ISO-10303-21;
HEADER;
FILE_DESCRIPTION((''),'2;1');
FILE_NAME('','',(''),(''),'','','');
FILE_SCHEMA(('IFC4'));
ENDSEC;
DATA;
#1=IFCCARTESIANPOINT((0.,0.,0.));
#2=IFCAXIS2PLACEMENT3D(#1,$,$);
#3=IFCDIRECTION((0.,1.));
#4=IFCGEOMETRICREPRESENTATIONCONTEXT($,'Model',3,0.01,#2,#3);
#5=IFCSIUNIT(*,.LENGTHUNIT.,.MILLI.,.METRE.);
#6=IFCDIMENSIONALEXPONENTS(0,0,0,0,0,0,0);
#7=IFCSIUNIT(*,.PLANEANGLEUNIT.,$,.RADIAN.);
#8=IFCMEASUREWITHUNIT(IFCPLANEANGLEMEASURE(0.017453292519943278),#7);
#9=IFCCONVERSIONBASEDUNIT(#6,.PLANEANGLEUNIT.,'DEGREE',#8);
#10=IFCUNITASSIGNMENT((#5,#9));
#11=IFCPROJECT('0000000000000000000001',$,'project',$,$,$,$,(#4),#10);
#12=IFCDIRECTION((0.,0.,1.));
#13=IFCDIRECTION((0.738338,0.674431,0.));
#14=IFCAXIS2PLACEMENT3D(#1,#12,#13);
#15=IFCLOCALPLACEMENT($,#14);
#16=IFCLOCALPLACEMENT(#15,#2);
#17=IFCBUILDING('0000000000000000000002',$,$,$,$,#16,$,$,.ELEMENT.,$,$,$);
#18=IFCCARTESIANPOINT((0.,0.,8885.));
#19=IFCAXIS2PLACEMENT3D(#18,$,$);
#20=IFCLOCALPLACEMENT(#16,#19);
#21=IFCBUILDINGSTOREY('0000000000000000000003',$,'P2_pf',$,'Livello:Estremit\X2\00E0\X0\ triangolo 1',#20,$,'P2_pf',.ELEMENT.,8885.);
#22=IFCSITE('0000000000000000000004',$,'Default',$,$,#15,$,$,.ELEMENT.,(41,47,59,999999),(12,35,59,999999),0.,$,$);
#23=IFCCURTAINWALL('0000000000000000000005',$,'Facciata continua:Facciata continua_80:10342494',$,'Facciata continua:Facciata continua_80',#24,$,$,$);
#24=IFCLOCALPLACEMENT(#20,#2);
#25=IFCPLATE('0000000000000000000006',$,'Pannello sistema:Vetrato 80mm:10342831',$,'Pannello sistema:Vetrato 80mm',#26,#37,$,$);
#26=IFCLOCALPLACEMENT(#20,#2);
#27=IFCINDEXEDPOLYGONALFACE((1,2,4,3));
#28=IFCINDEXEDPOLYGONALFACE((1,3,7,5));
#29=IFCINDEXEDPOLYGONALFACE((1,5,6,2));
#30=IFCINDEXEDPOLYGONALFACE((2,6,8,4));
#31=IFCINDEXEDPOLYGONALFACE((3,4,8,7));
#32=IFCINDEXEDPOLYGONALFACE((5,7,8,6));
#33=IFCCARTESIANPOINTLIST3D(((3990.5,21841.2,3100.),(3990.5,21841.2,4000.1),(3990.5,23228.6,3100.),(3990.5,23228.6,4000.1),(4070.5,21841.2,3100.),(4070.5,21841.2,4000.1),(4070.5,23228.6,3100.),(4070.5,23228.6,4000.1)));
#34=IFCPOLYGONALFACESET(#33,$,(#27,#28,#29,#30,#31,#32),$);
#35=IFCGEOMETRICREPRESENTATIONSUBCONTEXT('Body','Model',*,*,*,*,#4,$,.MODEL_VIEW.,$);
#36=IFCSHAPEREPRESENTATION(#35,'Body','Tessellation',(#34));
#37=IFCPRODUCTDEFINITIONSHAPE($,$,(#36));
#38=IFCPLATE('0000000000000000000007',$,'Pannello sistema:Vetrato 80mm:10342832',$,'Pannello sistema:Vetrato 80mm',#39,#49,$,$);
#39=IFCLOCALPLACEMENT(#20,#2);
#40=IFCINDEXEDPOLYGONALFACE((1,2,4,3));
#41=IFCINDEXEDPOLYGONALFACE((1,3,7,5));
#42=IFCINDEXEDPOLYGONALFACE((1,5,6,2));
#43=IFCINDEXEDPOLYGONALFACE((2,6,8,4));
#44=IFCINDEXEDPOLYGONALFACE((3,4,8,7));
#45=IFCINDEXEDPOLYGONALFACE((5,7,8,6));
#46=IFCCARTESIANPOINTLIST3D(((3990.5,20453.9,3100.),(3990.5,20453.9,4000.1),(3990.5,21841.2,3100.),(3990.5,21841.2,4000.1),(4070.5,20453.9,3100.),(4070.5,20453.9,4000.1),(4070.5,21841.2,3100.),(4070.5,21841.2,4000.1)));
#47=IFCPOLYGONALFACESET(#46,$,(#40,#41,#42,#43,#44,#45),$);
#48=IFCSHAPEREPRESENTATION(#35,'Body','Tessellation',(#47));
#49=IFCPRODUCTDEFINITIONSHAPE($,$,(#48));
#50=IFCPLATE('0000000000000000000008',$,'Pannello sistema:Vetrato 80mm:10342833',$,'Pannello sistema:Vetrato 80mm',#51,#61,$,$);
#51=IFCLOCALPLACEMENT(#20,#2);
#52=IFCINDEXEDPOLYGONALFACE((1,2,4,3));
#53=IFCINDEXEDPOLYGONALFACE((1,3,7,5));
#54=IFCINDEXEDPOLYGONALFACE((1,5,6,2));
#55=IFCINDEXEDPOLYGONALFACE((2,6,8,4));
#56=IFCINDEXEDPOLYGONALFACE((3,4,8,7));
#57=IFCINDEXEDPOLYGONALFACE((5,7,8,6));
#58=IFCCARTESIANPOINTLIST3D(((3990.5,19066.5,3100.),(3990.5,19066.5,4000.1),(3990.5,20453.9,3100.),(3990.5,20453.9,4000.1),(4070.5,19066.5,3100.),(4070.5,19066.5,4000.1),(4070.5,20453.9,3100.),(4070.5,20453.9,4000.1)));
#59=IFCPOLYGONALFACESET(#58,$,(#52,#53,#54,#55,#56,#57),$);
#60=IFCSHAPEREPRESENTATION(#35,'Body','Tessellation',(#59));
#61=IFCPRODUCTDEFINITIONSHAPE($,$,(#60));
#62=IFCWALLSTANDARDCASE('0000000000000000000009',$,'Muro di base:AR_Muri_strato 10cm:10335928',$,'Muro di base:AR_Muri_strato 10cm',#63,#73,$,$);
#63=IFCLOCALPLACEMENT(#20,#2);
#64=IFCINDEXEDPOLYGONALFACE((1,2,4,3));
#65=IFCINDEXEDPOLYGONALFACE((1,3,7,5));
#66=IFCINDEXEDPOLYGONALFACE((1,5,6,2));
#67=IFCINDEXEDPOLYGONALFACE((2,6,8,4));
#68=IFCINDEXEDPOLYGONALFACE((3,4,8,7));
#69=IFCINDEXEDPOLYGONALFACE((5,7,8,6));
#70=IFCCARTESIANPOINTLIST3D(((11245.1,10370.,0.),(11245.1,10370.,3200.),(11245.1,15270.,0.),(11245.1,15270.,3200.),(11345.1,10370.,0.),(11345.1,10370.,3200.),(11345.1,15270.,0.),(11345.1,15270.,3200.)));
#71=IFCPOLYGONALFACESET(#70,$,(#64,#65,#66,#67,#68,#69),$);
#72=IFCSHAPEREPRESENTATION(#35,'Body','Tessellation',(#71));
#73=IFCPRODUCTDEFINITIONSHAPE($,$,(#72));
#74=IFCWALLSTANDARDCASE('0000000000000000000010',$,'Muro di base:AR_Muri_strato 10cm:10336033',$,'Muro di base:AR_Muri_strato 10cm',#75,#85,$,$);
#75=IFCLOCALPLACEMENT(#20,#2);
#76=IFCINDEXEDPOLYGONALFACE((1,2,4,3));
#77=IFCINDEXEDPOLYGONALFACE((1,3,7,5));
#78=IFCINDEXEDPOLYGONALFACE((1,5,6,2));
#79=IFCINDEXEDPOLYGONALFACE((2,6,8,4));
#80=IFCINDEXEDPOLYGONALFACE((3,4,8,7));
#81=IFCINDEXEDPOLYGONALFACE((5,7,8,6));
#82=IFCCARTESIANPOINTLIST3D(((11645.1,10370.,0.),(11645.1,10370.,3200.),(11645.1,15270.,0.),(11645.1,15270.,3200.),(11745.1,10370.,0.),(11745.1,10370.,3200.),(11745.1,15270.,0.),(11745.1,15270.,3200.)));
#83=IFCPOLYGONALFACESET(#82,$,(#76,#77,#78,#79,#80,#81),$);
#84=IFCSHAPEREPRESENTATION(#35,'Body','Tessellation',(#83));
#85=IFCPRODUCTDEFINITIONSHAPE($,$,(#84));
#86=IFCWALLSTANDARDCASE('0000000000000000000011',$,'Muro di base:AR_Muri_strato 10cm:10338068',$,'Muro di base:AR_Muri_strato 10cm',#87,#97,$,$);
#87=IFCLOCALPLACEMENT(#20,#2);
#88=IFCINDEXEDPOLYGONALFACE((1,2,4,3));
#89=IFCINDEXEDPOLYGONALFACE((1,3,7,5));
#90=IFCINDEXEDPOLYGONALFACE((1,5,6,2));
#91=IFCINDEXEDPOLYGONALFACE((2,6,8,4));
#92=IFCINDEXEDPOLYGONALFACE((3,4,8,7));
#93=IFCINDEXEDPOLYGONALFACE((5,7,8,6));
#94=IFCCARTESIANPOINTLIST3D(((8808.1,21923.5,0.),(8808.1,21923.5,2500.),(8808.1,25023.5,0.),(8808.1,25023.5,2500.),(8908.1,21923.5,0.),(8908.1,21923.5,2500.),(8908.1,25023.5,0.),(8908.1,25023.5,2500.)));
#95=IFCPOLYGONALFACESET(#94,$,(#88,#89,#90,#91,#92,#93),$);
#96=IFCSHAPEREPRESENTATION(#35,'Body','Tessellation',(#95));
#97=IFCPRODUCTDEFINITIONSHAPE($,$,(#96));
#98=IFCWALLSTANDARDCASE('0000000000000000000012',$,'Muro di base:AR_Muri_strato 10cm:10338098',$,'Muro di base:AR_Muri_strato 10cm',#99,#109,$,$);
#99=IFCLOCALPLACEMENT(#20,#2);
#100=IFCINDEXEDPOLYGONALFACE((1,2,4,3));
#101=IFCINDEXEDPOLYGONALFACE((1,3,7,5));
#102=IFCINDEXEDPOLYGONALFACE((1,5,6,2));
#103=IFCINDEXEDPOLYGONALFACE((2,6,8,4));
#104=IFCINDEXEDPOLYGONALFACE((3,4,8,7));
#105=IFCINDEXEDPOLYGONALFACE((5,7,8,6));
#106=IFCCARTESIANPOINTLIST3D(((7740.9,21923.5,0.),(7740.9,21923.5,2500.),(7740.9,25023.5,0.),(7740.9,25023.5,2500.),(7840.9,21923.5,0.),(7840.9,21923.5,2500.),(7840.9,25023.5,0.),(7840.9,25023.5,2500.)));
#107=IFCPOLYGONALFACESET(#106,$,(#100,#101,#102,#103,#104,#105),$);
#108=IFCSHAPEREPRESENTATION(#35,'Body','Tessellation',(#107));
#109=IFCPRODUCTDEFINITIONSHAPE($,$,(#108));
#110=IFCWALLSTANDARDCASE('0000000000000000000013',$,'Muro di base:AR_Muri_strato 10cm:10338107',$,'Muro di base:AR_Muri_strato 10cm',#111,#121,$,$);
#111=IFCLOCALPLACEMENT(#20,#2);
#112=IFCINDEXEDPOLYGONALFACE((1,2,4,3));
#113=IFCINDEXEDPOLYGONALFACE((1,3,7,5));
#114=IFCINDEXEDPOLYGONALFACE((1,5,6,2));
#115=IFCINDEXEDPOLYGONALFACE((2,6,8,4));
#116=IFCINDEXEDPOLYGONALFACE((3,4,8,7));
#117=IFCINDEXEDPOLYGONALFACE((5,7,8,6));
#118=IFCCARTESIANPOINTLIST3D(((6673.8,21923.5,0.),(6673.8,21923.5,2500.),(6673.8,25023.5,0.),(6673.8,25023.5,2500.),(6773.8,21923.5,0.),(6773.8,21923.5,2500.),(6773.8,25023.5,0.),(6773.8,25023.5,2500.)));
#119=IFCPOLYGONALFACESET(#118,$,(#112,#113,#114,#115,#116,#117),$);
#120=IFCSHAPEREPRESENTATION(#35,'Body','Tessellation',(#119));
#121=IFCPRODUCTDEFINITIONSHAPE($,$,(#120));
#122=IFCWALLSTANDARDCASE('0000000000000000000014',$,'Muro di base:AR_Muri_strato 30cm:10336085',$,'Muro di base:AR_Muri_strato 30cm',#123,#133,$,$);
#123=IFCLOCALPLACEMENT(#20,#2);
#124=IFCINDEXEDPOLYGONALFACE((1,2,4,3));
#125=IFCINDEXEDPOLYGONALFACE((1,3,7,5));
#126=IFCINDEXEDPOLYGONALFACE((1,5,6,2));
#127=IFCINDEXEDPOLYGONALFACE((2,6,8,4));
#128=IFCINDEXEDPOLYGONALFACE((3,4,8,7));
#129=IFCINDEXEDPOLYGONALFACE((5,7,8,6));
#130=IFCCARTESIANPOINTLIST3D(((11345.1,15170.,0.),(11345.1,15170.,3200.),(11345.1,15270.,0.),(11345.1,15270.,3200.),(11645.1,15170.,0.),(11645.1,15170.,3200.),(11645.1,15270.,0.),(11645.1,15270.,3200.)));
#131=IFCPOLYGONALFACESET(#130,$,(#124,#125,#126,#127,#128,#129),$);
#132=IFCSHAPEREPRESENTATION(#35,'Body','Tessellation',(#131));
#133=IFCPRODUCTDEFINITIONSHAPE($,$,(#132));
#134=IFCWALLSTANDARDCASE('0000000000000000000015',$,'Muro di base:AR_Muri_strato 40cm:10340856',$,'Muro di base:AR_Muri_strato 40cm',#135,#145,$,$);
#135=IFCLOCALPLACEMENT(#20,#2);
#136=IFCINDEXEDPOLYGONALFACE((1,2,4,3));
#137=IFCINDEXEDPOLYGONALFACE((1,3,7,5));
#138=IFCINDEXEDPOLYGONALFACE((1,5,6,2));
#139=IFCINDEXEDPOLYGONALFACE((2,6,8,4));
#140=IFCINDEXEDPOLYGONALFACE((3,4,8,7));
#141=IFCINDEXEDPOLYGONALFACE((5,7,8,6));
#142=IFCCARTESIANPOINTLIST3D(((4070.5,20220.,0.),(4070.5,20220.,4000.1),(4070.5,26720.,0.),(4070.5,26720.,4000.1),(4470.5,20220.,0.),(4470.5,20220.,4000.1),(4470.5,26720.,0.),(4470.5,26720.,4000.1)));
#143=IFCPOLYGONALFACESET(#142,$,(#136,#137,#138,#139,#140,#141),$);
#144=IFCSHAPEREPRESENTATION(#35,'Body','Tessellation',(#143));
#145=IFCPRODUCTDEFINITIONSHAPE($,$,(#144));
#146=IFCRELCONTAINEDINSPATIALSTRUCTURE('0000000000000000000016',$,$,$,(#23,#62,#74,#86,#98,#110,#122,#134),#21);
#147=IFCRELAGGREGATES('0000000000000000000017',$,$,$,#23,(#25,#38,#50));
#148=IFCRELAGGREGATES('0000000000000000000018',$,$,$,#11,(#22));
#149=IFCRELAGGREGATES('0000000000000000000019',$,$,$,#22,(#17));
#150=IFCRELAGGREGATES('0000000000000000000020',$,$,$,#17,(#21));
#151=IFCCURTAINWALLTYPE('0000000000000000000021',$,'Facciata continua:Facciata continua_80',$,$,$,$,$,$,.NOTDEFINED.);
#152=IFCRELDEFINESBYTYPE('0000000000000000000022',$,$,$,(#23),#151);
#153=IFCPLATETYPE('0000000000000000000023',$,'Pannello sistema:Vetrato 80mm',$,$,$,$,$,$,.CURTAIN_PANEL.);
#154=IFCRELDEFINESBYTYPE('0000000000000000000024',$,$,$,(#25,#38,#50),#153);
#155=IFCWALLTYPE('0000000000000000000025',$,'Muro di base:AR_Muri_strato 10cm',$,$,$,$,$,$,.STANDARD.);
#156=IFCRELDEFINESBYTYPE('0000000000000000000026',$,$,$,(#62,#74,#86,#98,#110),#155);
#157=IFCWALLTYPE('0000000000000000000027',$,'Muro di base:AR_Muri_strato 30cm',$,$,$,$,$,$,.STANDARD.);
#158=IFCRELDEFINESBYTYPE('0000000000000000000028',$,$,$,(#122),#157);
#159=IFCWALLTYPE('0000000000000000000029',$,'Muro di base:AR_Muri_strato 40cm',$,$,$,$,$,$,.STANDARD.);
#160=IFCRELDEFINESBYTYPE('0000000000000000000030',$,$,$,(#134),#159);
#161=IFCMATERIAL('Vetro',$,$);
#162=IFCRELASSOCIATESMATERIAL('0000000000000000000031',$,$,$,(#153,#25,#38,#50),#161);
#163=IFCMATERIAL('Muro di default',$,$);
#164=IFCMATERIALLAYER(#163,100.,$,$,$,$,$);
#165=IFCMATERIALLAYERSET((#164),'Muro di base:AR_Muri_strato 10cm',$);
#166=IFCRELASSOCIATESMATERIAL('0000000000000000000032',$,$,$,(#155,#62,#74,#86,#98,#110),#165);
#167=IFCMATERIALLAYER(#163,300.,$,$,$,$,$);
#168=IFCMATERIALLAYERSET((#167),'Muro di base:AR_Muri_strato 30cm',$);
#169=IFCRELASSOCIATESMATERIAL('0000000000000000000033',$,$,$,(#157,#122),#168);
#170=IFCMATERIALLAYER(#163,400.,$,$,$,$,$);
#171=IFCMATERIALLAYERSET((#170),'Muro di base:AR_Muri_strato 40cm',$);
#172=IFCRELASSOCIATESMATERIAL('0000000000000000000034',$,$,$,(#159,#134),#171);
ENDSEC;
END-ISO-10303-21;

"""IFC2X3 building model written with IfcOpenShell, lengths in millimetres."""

from ifc_helpers import new_model, entity, si_unit, converted_unit, direction, frame, frame_2d, origin, place, context, subcontext, project, spatial, rectangle, extrude, source, transform, mapped, material, layer, layer_set, layer_usage, type_object, type_shapes, element, aggregate, save


model = new_model("IFC2X3")

# Units and contexts
model_context = context("Model", 3, precision=0.01, world=origin(), true_north=direction((0.0, 1.0)))
body_context = subcontext(model_context, "Body", "Model", "MODEL_VIEW")
ifc_project = project(units=[si_unit("LENGTHUNIT", "METRE", prefix="MILLI"), converted_unit("PLANEANGLEUNIT", "DEGREE", entity("IfcPlaneAngleMeasure", 0.017453292519943278), si_unit("PLANEANGLEUNIT", "RADIAN"), dimensions=[0, 0, 0, 0, 0, 0, 0])], contexts=[model_context])

# Site, building, storey
site_placement = place(None, frame((0.0, 0.0, 0.0), z_axis=(0.0, 0.0, 1.0), x_axis=(0.738338, 0.674431, 0.0)))
site = spatial("IfcSite", under=ifc_project, at=site_placement, Name="Default", CompositionType="ELEMENT", RefLatitude=(41, 47, 59, 999999), RefLongitude=(12, 35, 59, 999999), RefElevation=0.0)
building_placement = place(site_placement, origin())
building = spatial("IfcBuilding", under=site, at=building_placement, CompositionType="ELEMENT")
storey_placement = place(building_placement, frame((0.0, 0.0, 8885.0)))
storey = spatial("IfcBuildingStorey", under=building, at=storey_placement, Name="P2_pf", ObjectType="Livello:Estremità triangolo 1", LongName="P2_pf", CompositionType="ELEMENT", Elevation=8885.0)

# Curtain wall, plates
curtain_wall_type = type_object("IfcCurtainWallType", Name="Facciata continua:Facciata continua_80", PredefinedType="NOTDEFINED")
curtain_wall_placement = place(storey_placement, frame((0.0, 0.0, -8885.0)))
curtain_wall = element("IfcCurtainWall", 1, at=curtain_wall_placement, inside=storey, type_object=curtain_wall_type, Name="Facciata continua:Facciata continua_80:10342494", ObjectType="Facciata continua:Facciata continua_80")
ifc_material_1 = material(Name="Vetro")
plate_type_1 = type_object("IfcPlateType", Name="Pannello sistema:Vetrato 80mm", PredefinedType="CURTAIN_PANEL", material=ifc_material_1)
shared_shape_1 = source(origin(), body_context, "Body", "SweptSolid", [
    extrude(rectangle(XDim=80.0, YDim=1387.4, at=frame_2d((0.0, 0.0), x_axis=(1.0, 0.0))), frame((0.0, -40.0, 0.0), z_axis=(0.0, 0.0, 1.0), x_axis=(0.0, 1.0, 0.0)), (0.0, 0.0, 1.0), 900.1),
])
type_shapes(plate_type_1, [shared_shape_1])
plate_1_placement = place(curtain_wall_placement, frame((4070.5, 22534.9, 11985.0), z_axis=(0.0, 0.0, 1.0), x_axis=(0.0, -1.0, 0.0)))
plate_1 = element("IfcPlate", 2, at=plate_1_placement, type_object=plate_type_1, material=ifc_material_1, Name="Pannello sistema:Vetrato 80mm:10342831", ObjectType="Pannello sistema:Vetrato 80mm", context=body_context, shape_type="MappedRepresentation", body=[
    mapped(shared_shape_1, transform((0.0, 0.0, 0.0), scale=1.0)),
])
plate_2_placement = place(curtain_wall_placement, frame((4070.5, 21147.6, 11985.0), z_axis=(0.0, 0.0, 1.0), x_axis=(0.0, -1.0, 0.0)))
plate_2 = element("IfcPlate", 3, at=plate_2_placement, type_object=plate_type_1, material=ifc_material_1, Name="Pannello sistema:Vetrato 80mm:10342832", ObjectType="Pannello sistema:Vetrato 80mm", context=body_context, shape_type="MappedRepresentation", body=[
    mapped(shared_shape_1, transform((0.0, 0.0, 0.0), scale=1.0)),
])
plate_3_placement = place(curtain_wall_placement, frame((4070.5, 19760.2, 11985.0), z_axis=(0.0, 0.0, 1.0), x_axis=(0.0, -1.0, 0.0)))
plate_3 = element("IfcPlate", 4, at=plate_3_placement, type_object=plate_type_1, material=ifc_material_1, Name="Pannello sistema:Vetrato 80mm:10342833", ObjectType="Pannello sistema:Vetrato 80mm", context=body_context, shape_type="MappedRepresentation", body=[
    mapped(shared_shape_1, transform((0.0, 0.0, 0.0), scale=1.0)),
])
aggregate(curtain_wall, [plate_1, plate_2, plate_3])

# Walls
ifc_material_2 = material(Name="Muro di default")
ifc_layer_1 = layer(ifc_material_2, 100.0)
ifc_layer_set_1 = layer_set([ifc_layer_1], Name="Muro di base:AR_Muri_strato 10cm")
ifc_layer_usage_1 = layer_usage(ifc_layer_set_1, "AXIS2", "NEGATIVE", 50.0)
wall_type_1 = type_object("IfcWallType", Name="Muro di base:AR_Muri_strato 10cm", PredefinedType="STANDARD", material=ifc_layer_set_1)
wall_1_placement = place(storey_placement, frame((11295.1, 15270.0, 0.0), z_axis=(0.0, 0.0, 1.0), x_axis=(0.0, -1.0, 0.0)))
element("IfcWallStandardCase", 5, at=wall_1_placement, inside=storey, type_object=wall_type_1, material=ifc_layer_usage_1, Name="Muro di base:AR_Muri_strato 10cm:10335928", ObjectType="Muro di base:AR_Muri_strato 10cm", context=body_context, shape_type="SweptSolid", body=[
    extrude(rectangle(XDim=4900.0, YDim=100.0, at=frame_2d((2450.0, 0.0), x_axis=(-1.0, 0.0))), origin(), (0.0, 0.0, 1.0), 3200.0),
])
ifc_layer_usage_2 = layer_usage(ifc_layer_set_1, "AXIS2", "POSITIVE", -50.0)
wall_2_placement = place(storey_placement, frame((11695.1, 15270.0, 0.0), z_axis=(0.0, 0.0, 1.0), x_axis=(0.0, -1.0, 0.0)))
element("IfcWallStandardCase", 6, at=wall_2_placement, inside=storey, type_object=wall_type_1, material=ifc_layer_usage_2, Name="Muro di base:AR_Muri_strato 10cm:10336033", ObjectType="Muro di base:AR_Muri_strato 10cm", context=body_context, shape_type="SweptSolid", body=[
    extrude(rectangle(XDim=4900.0, YDim=100.0, at=frame_2d((2450.0, 0.0), x_axis=(-1.0, 0.0))), origin(), (0.0, 0.0, 1.0), 3200.0),
])
ifc_layer_usage_3 = layer_usage(ifc_layer_set_1, "AXIS2", "NEGATIVE", 50.0)
wall_3_placement = place(storey_placement, frame((8858.1, 25023.5, 0.0), z_axis=(0.0, 0.0, 1.0), x_axis=(0.0, -1.0, 0.0)))
element("IfcWallStandardCase", 7, at=wall_3_placement, inside=storey, type_object=wall_type_1, material=ifc_layer_usage_3, Name="Muro di base:AR_Muri_strato 10cm:10338068", ObjectType="Muro di base:AR_Muri_strato 10cm", context=body_context, shape_type="SweptSolid", body=[
    extrude(rectangle(XDim=3100.0, YDim=100.0, at=frame_2d((1550.0, 0.0), x_axis=(-1.0, 0.0))), origin(), (0.0, 0.0, 1.0), 2500.0),
])
ifc_layer_usage_4 = layer_usage(ifc_layer_set_1, "AXIS2", "NEGATIVE", 50.0)
wall_4_placement = place(storey_placement, frame((7790.9, 25023.5, 0.0), z_axis=(0.0, 0.0, 1.0), x_axis=(0.0, -1.0, 0.0)))
element("IfcWallStandardCase", 8, at=wall_4_placement, inside=storey, type_object=wall_type_1, material=ifc_layer_usage_4, Name="Muro di base:AR_Muri_strato 10cm:10338098", ObjectType="Muro di base:AR_Muri_strato 10cm", context=body_context, shape_type="SweptSolid", body=[
    extrude(rectangle(XDim=3100.0, YDim=100.0, at=frame_2d((1550.0, 0.0), x_axis=(-1.0, 0.0))), origin(), (0.0, 0.0, 1.0), 2500.0),
])
ifc_layer_usage_5 = layer_usage(ifc_layer_set_1, "AXIS2", "NEGATIVE", 50.0)
wall_5_placement = place(storey_placement, frame((6723.8, 25023.5, 0.0), z_axis=(0.0, 0.0, 1.0), x_axis=(0.0, -1.0, 0.0)))
element("IfcWallStandardCase", 9, at=wall_5_placement, inside=storey, type_object=wall_type_1, material=ifc_layer_usage_5, Name="Muro di base:AR_Muri_strato 10cm:10338107", ObjectType="Muro di base:AR_Muri_strato 10cm", context=body_context, shape_type="SweptSolid", body=[
    extrude(rectangle(XDim=3100.0, YDim=100.0, at=frame_2d((1550.0, 0.0), x_axis=(-1.0, 0.0))), origin(), (0.0, 0.0, 1.0), 2500.0),
])
ifc_layer_2 = layer(ifc_material_2, 300.0)
ifc_layer_set_2 = layer_set([ifc_layer_2], Name="Muro di base:AR_Muri_strato 30cm")
ifc_layer_usage_6 = layer_usage(ifc_layer_set_2, "AXIS2", "NEGATIVE", 150.0)
wall_type_2 = type_object("IfcWallType", Name="Muro di base:AR_Muri_strato 30cm", PredefinedType="STANDARD", material=ifc_layer_set_2)
wall_6_placement = place(storey_placement, frame((11495.1, 15170.0, 0.0), z_axis=(0.0, 0.0, 1.0), x_axis=(0.0, 1.0, 0.0)))
element("IfcWallStandardCase", 10, at=wall_6_placement, inside=storey, type_object=wall_type_2, material=ifc_layer_usage_6, Name="Muro di base:AR_Muri_strato 30cm:10336085", ObjectType="Muro di base:AR_Muri_strato 30cm", context=body_context, shape_type="SweptSolid", body=[
    extrude(rectangle(XDim=100.0, YDim=300.0, at=frame_2d((50.0, 0.0), x_axis=(-1.0, 0.0))), origin(), (0.0, 0.0, 1.0), 3200.0),
])
ifc_layer_3 = layer(ifc_material_2, 400.0)
ifc_layer_set_3 = layer_set([ifc_layer_3], Name="Muro di base:AR_Muri_strato 40cm")
ifc_layer_usage_7 = layer_usage(ifc_layer_set_3, "AXIS2", "NEGATIVE", 200.0)
wall_type_3 = type_object("IfcWallType", Name="Muro di base:AR_Muri_strato 40cm", PredefinedType="STANDARD", material=ifc_layer_set_3)
wall_7_placement = place(storey_placement, frame((4270.5, 20220.0, 0.0), z_axis=(0.0, 0.0, 1.0), x_axis=(0.0, 1.0, 0.0)))
element("IfcWallStandardCase", 11, at=wall_7_placement, inside=storey, type_object=wall_type_3, material=ifc_layer_usage_7, Name="Muro di base:AR_Muri_strato 40cm:10340856", ObjectType="Muro di base:AR_Muri_strato 40cm", context=body_context, shape_type="SweptSolid", body=[
    extrude(rectangle(XDim=6500.0, YDim=400.0, at=frame_2d((3250.0, 0.0), x_axis=(-1.0, 0.0))), origin(), (0.0, 0.0, 1.0), 4000.1),
])

save(model, "model.ifc")
